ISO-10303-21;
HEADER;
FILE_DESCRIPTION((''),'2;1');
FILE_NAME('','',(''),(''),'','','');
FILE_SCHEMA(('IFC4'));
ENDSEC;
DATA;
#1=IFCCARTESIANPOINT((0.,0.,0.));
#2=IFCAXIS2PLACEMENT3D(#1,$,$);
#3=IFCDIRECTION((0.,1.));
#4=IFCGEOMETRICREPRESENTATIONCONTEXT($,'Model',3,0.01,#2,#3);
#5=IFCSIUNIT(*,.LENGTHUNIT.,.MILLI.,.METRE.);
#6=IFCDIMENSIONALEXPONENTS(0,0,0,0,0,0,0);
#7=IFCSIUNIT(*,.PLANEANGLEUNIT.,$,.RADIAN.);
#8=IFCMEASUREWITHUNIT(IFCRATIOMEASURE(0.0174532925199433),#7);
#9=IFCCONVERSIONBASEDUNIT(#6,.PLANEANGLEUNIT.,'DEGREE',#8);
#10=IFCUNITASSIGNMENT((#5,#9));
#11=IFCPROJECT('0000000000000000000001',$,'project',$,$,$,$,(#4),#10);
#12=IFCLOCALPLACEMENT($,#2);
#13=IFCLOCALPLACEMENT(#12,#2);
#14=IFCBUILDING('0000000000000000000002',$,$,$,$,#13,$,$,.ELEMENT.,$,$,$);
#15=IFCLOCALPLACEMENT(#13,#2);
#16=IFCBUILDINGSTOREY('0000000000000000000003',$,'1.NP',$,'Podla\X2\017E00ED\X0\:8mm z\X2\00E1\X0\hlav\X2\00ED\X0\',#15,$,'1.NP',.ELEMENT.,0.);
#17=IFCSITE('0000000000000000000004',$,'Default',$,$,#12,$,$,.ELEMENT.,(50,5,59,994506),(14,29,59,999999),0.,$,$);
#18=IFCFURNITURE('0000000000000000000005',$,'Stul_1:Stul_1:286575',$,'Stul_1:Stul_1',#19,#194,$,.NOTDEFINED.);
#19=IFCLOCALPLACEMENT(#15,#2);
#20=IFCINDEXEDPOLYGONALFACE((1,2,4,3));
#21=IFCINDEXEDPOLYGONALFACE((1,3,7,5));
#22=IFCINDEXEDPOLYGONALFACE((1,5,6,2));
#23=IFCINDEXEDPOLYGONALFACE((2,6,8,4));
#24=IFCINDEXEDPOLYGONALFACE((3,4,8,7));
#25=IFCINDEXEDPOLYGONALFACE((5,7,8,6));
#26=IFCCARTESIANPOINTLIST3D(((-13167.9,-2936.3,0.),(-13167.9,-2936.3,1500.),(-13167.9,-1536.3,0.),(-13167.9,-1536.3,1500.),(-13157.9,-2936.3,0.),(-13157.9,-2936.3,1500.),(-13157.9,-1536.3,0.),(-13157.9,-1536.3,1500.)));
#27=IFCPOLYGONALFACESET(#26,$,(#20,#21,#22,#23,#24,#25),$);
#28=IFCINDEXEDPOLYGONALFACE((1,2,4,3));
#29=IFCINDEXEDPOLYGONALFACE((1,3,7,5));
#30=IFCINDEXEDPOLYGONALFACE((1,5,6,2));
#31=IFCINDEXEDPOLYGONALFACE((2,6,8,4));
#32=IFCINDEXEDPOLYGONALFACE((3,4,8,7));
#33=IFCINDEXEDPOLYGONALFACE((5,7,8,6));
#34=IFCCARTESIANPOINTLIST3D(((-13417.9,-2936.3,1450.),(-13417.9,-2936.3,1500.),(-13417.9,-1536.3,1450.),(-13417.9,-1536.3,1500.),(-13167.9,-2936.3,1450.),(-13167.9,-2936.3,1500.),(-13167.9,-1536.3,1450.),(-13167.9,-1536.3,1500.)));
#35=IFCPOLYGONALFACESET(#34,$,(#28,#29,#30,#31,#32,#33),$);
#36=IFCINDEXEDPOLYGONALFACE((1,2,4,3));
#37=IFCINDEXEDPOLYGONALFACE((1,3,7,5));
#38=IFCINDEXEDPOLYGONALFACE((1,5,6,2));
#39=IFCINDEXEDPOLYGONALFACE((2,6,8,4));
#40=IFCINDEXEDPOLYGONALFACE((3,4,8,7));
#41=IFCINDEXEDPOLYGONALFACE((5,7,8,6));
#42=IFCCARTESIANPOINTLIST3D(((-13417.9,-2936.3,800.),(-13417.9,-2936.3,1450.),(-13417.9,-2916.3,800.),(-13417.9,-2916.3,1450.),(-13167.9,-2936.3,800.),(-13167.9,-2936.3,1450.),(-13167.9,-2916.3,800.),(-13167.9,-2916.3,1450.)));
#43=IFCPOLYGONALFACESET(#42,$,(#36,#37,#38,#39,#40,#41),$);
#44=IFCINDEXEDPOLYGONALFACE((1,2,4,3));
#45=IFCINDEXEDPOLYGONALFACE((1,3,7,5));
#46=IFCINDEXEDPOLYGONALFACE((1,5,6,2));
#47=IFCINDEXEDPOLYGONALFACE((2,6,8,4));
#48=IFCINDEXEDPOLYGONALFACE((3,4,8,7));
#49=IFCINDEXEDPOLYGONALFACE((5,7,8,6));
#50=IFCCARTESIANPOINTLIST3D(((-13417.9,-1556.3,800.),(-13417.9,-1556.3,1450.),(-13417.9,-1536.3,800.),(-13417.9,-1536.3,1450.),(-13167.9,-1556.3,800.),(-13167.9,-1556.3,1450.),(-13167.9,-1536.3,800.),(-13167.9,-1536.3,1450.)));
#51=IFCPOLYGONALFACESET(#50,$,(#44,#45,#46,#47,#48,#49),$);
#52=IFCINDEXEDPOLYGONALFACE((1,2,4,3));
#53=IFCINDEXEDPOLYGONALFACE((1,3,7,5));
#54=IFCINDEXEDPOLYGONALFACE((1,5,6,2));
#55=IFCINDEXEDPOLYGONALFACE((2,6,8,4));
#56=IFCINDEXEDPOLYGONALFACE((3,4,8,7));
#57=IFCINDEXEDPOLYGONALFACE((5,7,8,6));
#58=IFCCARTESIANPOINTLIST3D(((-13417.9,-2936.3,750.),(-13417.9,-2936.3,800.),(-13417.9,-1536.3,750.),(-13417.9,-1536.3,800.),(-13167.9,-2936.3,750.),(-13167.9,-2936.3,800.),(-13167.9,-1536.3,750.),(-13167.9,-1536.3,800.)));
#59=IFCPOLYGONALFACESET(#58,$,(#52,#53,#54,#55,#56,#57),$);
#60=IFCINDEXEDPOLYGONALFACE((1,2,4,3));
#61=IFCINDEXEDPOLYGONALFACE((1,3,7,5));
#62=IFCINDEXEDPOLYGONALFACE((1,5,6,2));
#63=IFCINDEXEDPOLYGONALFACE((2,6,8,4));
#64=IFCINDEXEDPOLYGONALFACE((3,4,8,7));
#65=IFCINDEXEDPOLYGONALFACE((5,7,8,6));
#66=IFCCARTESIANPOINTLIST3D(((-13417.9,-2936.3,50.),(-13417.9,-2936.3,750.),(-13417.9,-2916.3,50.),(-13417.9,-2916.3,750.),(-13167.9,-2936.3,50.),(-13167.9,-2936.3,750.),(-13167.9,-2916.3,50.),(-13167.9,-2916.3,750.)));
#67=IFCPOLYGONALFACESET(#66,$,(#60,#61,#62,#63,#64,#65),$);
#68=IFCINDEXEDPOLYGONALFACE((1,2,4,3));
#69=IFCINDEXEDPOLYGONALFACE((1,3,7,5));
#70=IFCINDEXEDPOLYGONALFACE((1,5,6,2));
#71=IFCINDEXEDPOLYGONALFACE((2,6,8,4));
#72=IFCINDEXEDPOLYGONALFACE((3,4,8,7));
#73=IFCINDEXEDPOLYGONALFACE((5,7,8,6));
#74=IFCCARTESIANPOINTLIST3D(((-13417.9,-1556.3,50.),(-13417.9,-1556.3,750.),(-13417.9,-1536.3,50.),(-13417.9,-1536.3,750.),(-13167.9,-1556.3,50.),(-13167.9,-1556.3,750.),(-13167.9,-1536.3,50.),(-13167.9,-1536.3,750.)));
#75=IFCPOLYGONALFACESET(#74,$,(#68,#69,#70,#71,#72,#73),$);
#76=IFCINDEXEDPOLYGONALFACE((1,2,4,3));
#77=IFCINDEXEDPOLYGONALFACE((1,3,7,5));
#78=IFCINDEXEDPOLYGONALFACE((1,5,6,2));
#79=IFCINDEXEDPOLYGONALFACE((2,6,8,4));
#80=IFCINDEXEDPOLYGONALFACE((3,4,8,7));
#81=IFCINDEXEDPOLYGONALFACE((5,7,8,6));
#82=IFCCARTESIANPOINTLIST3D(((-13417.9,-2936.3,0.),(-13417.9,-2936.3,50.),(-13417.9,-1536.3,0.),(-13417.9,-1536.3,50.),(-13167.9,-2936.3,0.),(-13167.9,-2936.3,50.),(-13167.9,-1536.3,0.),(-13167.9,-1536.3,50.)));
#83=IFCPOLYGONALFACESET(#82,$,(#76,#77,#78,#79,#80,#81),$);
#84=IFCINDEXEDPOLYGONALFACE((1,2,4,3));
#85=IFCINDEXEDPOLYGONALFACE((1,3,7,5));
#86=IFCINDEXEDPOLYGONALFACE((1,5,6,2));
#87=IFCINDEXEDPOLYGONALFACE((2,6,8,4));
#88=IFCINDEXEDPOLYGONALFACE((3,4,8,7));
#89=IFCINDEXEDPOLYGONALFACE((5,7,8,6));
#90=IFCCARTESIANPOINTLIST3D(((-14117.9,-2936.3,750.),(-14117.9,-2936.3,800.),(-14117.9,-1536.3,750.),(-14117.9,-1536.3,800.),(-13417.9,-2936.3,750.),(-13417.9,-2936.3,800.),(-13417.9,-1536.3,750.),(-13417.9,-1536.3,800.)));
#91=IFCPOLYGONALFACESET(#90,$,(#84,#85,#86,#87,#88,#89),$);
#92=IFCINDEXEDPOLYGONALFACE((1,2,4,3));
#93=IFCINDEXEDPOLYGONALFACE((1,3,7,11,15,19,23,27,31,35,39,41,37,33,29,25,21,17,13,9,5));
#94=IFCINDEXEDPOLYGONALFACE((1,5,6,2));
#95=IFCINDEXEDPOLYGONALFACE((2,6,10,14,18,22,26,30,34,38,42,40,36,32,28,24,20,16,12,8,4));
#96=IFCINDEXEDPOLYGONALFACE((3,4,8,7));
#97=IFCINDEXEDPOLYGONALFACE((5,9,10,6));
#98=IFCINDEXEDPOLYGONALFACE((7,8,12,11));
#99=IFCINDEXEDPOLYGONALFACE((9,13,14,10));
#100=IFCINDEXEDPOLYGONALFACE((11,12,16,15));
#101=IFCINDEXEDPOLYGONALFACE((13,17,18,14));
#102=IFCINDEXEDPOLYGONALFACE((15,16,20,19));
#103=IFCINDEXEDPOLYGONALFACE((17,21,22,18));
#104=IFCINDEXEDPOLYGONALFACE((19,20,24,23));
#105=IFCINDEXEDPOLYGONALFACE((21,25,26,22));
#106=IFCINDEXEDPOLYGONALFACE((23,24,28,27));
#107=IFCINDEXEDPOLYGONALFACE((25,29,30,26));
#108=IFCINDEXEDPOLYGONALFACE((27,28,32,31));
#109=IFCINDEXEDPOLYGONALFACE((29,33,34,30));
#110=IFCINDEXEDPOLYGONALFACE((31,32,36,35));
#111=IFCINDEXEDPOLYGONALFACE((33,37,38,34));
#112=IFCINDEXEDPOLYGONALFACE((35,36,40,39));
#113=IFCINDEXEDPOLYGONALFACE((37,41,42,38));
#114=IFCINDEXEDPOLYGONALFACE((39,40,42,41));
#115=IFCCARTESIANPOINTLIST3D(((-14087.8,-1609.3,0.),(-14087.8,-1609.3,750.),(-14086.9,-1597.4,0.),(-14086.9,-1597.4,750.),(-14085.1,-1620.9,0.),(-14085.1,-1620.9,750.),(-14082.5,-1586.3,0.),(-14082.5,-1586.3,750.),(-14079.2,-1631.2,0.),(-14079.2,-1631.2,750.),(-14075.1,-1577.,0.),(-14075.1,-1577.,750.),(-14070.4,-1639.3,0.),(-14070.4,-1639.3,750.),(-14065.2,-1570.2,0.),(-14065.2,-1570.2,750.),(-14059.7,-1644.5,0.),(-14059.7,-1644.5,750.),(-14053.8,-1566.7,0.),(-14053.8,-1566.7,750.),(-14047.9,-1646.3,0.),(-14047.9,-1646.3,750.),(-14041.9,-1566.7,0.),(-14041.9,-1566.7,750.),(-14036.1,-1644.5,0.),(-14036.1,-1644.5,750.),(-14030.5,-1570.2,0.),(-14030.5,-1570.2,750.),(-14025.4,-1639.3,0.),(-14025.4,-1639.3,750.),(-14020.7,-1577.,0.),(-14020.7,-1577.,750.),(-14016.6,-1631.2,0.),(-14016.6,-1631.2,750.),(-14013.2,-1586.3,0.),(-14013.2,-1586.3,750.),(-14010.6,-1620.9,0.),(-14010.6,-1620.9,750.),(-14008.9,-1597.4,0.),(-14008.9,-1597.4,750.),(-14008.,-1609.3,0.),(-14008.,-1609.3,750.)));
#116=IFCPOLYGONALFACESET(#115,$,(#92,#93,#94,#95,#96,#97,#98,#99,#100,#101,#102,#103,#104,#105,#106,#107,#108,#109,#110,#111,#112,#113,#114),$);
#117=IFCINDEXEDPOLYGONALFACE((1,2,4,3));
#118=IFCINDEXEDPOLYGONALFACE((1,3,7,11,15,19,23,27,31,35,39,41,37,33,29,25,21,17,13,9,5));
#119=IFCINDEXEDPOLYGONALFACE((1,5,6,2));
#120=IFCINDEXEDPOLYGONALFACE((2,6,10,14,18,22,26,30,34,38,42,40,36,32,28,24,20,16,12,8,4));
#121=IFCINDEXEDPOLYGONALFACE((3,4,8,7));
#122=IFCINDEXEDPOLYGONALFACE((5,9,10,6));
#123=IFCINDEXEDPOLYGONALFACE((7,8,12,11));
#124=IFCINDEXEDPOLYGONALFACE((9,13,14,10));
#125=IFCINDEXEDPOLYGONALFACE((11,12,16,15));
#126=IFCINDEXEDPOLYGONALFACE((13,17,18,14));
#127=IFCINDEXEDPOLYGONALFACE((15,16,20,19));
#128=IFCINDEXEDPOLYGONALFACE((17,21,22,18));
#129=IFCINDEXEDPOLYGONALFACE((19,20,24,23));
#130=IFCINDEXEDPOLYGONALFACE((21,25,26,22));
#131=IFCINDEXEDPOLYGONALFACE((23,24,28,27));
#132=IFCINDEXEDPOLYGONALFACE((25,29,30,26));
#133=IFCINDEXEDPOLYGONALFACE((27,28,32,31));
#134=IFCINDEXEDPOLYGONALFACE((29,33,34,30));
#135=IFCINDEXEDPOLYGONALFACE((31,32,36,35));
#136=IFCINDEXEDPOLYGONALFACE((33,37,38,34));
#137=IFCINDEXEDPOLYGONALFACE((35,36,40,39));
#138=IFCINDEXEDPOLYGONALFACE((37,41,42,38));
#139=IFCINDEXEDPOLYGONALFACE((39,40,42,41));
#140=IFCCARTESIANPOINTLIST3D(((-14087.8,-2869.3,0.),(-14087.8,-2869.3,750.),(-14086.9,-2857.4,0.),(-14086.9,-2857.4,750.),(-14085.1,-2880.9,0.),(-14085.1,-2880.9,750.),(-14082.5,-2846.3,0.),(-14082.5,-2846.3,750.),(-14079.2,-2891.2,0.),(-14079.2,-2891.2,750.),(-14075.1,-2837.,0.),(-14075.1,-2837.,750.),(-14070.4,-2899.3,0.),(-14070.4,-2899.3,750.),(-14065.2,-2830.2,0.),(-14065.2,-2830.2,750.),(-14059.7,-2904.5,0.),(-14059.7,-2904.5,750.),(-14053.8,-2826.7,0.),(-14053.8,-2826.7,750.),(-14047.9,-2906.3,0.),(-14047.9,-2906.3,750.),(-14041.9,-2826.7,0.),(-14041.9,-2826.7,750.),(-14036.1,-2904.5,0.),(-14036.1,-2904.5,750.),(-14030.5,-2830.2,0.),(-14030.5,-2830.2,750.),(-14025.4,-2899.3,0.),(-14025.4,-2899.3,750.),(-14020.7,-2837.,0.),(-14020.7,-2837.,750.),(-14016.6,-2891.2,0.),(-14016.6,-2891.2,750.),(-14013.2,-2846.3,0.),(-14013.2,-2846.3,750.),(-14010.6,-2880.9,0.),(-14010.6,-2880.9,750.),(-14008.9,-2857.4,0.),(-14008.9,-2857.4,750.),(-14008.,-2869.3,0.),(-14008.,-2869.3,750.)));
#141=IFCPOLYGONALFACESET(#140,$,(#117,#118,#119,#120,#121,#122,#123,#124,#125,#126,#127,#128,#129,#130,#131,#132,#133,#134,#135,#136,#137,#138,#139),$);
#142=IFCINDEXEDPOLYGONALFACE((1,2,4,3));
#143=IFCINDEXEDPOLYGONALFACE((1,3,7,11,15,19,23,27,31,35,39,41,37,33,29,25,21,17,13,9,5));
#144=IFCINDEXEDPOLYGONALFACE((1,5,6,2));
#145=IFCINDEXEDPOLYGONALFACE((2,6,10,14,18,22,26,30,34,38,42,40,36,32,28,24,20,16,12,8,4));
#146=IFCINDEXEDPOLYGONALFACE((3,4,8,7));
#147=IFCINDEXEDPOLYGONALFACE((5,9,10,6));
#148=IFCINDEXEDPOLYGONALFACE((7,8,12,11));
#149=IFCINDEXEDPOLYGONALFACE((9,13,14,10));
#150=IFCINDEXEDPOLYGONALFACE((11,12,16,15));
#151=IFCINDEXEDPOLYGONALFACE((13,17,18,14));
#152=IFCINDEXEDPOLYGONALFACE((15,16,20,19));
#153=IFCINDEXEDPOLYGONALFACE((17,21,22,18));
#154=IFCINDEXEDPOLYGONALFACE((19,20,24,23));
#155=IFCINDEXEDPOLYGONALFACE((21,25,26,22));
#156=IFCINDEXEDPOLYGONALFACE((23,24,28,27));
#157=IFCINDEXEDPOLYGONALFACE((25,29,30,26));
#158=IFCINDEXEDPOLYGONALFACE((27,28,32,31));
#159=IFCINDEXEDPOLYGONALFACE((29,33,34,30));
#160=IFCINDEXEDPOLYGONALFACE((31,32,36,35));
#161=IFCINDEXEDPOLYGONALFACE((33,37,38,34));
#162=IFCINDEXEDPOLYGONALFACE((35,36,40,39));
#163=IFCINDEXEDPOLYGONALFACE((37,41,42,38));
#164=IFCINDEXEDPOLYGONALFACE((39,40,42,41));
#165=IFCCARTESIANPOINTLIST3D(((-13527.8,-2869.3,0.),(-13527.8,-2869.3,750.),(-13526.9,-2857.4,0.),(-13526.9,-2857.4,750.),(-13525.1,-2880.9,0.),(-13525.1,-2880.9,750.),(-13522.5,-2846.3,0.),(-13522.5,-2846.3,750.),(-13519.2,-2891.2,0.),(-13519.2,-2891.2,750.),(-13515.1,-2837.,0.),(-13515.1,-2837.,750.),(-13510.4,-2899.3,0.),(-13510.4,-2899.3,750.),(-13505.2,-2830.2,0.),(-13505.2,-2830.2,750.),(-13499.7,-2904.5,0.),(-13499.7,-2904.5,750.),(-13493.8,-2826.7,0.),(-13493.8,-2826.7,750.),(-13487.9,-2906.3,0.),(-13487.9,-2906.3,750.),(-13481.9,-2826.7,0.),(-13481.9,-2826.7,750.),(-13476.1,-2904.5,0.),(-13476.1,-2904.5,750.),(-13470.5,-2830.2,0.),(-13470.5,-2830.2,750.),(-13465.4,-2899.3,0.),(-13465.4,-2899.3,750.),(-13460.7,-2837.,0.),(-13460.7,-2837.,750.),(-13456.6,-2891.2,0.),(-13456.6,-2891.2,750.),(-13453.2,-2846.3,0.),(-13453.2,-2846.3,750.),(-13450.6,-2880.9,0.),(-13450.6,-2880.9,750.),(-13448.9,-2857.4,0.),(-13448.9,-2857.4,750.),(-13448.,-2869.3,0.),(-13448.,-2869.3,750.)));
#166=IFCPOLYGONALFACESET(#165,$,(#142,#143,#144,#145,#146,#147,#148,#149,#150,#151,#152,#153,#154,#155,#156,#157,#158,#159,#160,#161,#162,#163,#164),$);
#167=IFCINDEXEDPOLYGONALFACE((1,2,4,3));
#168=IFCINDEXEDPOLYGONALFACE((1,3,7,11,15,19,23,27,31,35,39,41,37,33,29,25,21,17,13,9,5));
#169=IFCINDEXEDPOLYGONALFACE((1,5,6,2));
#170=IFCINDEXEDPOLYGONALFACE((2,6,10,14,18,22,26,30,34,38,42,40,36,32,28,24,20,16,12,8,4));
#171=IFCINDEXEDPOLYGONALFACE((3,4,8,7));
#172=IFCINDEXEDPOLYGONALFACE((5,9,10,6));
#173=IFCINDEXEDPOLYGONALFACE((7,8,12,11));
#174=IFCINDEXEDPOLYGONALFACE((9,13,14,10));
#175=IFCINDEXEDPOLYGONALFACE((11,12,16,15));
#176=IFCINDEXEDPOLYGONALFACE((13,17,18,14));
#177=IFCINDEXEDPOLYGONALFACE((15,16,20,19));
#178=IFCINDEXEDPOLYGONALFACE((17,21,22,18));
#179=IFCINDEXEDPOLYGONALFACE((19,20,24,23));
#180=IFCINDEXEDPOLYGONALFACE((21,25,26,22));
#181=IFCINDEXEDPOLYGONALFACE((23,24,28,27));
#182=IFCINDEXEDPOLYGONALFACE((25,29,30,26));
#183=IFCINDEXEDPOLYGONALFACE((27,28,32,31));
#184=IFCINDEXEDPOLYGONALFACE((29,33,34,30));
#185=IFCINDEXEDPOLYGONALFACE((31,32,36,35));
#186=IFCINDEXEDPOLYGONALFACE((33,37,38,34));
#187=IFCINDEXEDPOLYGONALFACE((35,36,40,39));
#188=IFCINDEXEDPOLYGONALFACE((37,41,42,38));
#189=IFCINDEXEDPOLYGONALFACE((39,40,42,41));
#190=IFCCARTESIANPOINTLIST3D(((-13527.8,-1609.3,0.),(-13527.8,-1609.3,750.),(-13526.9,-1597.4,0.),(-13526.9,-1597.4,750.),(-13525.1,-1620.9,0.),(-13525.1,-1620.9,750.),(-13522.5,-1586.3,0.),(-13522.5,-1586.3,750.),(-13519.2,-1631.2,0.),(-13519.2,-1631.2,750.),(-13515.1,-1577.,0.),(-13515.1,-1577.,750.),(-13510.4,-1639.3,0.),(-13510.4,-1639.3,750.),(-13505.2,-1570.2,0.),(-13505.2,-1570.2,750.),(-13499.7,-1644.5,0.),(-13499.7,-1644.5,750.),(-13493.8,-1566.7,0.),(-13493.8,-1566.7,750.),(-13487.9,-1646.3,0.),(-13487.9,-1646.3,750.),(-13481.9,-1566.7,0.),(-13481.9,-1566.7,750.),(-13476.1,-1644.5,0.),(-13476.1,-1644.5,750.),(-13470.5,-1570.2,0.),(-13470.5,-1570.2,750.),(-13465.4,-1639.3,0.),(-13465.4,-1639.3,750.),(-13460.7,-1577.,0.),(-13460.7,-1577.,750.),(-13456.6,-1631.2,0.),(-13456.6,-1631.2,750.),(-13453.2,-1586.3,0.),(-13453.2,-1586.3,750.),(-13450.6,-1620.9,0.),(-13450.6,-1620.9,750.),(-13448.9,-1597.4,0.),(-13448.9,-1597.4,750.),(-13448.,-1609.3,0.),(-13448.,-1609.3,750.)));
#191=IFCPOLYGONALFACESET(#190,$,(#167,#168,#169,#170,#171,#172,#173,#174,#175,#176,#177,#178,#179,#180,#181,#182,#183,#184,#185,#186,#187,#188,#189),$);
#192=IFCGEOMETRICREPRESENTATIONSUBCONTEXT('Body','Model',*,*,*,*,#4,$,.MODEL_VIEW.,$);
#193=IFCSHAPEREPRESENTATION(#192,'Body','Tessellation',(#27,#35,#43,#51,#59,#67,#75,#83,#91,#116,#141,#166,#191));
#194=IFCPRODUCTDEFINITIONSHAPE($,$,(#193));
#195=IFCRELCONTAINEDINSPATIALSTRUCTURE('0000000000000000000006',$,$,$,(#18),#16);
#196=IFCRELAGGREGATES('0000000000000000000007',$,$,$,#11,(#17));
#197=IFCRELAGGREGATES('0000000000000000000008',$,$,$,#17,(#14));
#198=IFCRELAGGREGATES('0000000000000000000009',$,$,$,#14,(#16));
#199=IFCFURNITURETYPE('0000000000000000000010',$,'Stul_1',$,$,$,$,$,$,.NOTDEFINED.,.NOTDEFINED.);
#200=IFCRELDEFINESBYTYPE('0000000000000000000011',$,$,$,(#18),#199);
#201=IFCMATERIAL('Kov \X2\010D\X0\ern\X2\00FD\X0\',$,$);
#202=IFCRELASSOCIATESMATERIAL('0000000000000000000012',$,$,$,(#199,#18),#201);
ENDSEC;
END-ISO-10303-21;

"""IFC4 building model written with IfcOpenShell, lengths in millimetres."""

from ifc_helpers import new_model, entity, si_unit, converted_unit, direction, frame, frame_2d, origin, origin_2d_with_axis, place, context, subcontext, project, spatial, rectangle, circle, extrude, source, transform, mapped, material, type_object, type_shapes, element, save


model = new_model("IFC4")

# Units and contexts
model_context = context("Model", 3, precision=0.01, world=origin(), true_north=direction((0.0, 1.0)))
body_context = subcontext(model_context, "Body", "Model", "MODEL_VIEW")
ifc_project = project(units=[si_unit("LENGTHUNIT", "METRE", prefix="MILLI"), converted_unit("PLANEANGLEUNIT", "DEGREE", entity("IfcRatioMeasure", 0.0174532925199433), si_unit("PLANEANGLEUNIT", "RADIAN"), dimensions=[0, 0, 0, 0, 0, 0, 0])], contexts=[model_context])

# Site, building, storey
site_placement = place(None, origin())
site = spatial("IfcSite", under=ifc_project, at=site_placement, Name="Default", CompositionType="ELEMENT", RefLatitude=(50, 5, 59, 994506), RefLongitude=(14, 29, 59, 999999), RefElevation=0.0)
building_placement = place(site_placement, origin())
building = spatial("IfcBuilding", under=site, at=building_placement, CompositionType="ELEMENT")
storey_placement = place(building_placement, origin())
storey = spatial("IfcBuildingStorey", under=building, at=storey_placement, Name="1.NP", ObjectType="Podlaží:8mm záhlaví", LongName="1.NP", CompositionType="ELEMENT", Elevation=0.0)

# Furniture
ifc_material_1 = material(Name="Kov černý")
furniture_type = type_object("IfcFurnitureType", Name="Stul_1", AssemblyPlace="NOTDEFINED", PredefinedType="NOTDEFINED", material=ifc_material_1)
shared_shape_1 = source(origin(), body_context, "Body", "SweptSolid", [
    extrude(rectangle(XDim=1400.0, YDim=10.0, at=origin_2d_with_axis()), frame((0.0, 605.0, 0.0), z_axis=(0.0, 0.0, 1.0), x_axis=(-1.0, 0.0, 0.0)), (0.0, 0.0, 1.0), 1500.0),
    extrude(rectangle(XDim=1400.0, YDim=250.0, at=frame_2d((0.0, 0.0), x_axis=(1.0, 0.0))), frame((0.0, 475.0, 1450.0), z_axis=(0.0, 0.0, 1.0), x_axis=(-1.0, 0.0, 0.0)), (0.0, 0.0, 1.0), 50.0),
    extrude(rectangle(XDim=20.0, YDim=250.0, at=origin_2d_with_axis()), frame((690.0, 475.0, 800.0), z_axis=(0.0, 0.0, 1.0), x_axis=(-1.0, 0.0, 0.0)), (0.0, 0.0, 1.0), 650.0),
    extrude(rectangle(XDim=20.0, YDim=250.0, at=frame_2d((0.0, 0.0), x_axis=(1.0, 0.0))), frame((-690.0, 475.0, 800.0), z_axis=(0.0, 0.0, 1.0), x_axis=(-1.0, 0.0, 0.0)), (0.0, 0.0, 1.0), 650.0),
    extrude(rectangle(XDim=1400.0, YDim=250.0, at=origin_2d_with_axis()), frame((0.0, 475.0, 750.0), z_axis=(0.0, 0.0, 1.0), x_axis=(-1.0, 0.0, 0.0)), (0.0, 0.0, 1.0), 50.0),
    extrude(rectangle(XDim=20.0, YDim=250.0, at=origin_2d_with_axis()), frame((690.0, 475.0, 50.0), z_axis=(0.0, 0.0, 1.0), x_axis=(-1.0, 0.0, 0.0)), (0.0, 0.0, 1.0), 700.0),
    extrude(rectangle(XDim=20.0, YDim=250.0, at=frame_2d((0.0, 0.0), x_axis=(1.0, 0.0))), frame((-690.0, 475.0, 50.0), z_axis=(0.0, 0.0, 1.0), x_axis=(-1.0, 0.0, 0.0)), (0.0, 0.0, 1.0), 700.0),
    extrude(rectangle(XDim=1400.0, YDim=250.0, at=origin_2d_with_axis()), frame((0.0, 475.0, 0.0), z_axis=(0.0, 0.0, 1.0), x_axis=(-1.0, 0.0, 0.0)), (0.0, 0.0, 1.0), 50.0),
    extrude(rectangle(XDim=1400.0, YDim=700.0, at=origin_2d_with_axis()), frame((0.0, 0.0, 750.0), z_axis=(0.0, 0.0, 1.0), x_axis=(-1.0, 0.0, 0.0)), (0.0, 0.0, 1.0), 50.0),
    extrude(circle(Radius=40.0, at=frame_2d((0.0, 0.0), x_axis=(1.0, 0.0))), frame((-630.0, -280.0, 0.0)), (0.0, 0.0, 1.0), 750.0),
    extrude(circle(Radius=40.0, at=frame_2d((0.0, 0.0), x_axis=(1.0, 0.0))), frame((630.0, -280.0, 0.0)), (0.0, 0.0, 1.0), 750.0),
    extrude(circle(Radius=40.0, at=frame_2d((0.0, 0.0), x_axis=(1.0, 0.0))), frame((630.0, 280.0, 0.0)), (0.0, 0.0, 1.0), 750.0),
    extrude(circle(Radius=40.0, at=frame_2d((0.0, 0.0), x_axis=(1.0, 0.0))), frame((-630.0, 280.0, 0.0)), (0.0, 0.0, 1.0), 750.0),
])
type_shapes(furniture_type, [shared_shape_1])
for number, where, z_axis, x_axis, name in (
    (1, (-13767.9, -2236.3, 0.0), (0.0, 0.0, 1.0), (0.0, -1.0, 0.0), "Stul_1:Stul_1:286575"),
):
    element("IfcFurniture", number, at=place(storey_placement, frame(where, z_axis=z_axis, x_axis=x_axis)), inside=storey, type_object=furniture_type, material=ifc_material_1, Name=name, ObjectType="Stul_1:Stul_1", PredefinedType="NOTDEFINED", context=body_context, shape_type="MappedRepresentation", body=[
        mapped(shared_shape_1, transform((0.0, 0.0, 0.0), scale=1.0)),
    ])

save(model, "model.ifc")
